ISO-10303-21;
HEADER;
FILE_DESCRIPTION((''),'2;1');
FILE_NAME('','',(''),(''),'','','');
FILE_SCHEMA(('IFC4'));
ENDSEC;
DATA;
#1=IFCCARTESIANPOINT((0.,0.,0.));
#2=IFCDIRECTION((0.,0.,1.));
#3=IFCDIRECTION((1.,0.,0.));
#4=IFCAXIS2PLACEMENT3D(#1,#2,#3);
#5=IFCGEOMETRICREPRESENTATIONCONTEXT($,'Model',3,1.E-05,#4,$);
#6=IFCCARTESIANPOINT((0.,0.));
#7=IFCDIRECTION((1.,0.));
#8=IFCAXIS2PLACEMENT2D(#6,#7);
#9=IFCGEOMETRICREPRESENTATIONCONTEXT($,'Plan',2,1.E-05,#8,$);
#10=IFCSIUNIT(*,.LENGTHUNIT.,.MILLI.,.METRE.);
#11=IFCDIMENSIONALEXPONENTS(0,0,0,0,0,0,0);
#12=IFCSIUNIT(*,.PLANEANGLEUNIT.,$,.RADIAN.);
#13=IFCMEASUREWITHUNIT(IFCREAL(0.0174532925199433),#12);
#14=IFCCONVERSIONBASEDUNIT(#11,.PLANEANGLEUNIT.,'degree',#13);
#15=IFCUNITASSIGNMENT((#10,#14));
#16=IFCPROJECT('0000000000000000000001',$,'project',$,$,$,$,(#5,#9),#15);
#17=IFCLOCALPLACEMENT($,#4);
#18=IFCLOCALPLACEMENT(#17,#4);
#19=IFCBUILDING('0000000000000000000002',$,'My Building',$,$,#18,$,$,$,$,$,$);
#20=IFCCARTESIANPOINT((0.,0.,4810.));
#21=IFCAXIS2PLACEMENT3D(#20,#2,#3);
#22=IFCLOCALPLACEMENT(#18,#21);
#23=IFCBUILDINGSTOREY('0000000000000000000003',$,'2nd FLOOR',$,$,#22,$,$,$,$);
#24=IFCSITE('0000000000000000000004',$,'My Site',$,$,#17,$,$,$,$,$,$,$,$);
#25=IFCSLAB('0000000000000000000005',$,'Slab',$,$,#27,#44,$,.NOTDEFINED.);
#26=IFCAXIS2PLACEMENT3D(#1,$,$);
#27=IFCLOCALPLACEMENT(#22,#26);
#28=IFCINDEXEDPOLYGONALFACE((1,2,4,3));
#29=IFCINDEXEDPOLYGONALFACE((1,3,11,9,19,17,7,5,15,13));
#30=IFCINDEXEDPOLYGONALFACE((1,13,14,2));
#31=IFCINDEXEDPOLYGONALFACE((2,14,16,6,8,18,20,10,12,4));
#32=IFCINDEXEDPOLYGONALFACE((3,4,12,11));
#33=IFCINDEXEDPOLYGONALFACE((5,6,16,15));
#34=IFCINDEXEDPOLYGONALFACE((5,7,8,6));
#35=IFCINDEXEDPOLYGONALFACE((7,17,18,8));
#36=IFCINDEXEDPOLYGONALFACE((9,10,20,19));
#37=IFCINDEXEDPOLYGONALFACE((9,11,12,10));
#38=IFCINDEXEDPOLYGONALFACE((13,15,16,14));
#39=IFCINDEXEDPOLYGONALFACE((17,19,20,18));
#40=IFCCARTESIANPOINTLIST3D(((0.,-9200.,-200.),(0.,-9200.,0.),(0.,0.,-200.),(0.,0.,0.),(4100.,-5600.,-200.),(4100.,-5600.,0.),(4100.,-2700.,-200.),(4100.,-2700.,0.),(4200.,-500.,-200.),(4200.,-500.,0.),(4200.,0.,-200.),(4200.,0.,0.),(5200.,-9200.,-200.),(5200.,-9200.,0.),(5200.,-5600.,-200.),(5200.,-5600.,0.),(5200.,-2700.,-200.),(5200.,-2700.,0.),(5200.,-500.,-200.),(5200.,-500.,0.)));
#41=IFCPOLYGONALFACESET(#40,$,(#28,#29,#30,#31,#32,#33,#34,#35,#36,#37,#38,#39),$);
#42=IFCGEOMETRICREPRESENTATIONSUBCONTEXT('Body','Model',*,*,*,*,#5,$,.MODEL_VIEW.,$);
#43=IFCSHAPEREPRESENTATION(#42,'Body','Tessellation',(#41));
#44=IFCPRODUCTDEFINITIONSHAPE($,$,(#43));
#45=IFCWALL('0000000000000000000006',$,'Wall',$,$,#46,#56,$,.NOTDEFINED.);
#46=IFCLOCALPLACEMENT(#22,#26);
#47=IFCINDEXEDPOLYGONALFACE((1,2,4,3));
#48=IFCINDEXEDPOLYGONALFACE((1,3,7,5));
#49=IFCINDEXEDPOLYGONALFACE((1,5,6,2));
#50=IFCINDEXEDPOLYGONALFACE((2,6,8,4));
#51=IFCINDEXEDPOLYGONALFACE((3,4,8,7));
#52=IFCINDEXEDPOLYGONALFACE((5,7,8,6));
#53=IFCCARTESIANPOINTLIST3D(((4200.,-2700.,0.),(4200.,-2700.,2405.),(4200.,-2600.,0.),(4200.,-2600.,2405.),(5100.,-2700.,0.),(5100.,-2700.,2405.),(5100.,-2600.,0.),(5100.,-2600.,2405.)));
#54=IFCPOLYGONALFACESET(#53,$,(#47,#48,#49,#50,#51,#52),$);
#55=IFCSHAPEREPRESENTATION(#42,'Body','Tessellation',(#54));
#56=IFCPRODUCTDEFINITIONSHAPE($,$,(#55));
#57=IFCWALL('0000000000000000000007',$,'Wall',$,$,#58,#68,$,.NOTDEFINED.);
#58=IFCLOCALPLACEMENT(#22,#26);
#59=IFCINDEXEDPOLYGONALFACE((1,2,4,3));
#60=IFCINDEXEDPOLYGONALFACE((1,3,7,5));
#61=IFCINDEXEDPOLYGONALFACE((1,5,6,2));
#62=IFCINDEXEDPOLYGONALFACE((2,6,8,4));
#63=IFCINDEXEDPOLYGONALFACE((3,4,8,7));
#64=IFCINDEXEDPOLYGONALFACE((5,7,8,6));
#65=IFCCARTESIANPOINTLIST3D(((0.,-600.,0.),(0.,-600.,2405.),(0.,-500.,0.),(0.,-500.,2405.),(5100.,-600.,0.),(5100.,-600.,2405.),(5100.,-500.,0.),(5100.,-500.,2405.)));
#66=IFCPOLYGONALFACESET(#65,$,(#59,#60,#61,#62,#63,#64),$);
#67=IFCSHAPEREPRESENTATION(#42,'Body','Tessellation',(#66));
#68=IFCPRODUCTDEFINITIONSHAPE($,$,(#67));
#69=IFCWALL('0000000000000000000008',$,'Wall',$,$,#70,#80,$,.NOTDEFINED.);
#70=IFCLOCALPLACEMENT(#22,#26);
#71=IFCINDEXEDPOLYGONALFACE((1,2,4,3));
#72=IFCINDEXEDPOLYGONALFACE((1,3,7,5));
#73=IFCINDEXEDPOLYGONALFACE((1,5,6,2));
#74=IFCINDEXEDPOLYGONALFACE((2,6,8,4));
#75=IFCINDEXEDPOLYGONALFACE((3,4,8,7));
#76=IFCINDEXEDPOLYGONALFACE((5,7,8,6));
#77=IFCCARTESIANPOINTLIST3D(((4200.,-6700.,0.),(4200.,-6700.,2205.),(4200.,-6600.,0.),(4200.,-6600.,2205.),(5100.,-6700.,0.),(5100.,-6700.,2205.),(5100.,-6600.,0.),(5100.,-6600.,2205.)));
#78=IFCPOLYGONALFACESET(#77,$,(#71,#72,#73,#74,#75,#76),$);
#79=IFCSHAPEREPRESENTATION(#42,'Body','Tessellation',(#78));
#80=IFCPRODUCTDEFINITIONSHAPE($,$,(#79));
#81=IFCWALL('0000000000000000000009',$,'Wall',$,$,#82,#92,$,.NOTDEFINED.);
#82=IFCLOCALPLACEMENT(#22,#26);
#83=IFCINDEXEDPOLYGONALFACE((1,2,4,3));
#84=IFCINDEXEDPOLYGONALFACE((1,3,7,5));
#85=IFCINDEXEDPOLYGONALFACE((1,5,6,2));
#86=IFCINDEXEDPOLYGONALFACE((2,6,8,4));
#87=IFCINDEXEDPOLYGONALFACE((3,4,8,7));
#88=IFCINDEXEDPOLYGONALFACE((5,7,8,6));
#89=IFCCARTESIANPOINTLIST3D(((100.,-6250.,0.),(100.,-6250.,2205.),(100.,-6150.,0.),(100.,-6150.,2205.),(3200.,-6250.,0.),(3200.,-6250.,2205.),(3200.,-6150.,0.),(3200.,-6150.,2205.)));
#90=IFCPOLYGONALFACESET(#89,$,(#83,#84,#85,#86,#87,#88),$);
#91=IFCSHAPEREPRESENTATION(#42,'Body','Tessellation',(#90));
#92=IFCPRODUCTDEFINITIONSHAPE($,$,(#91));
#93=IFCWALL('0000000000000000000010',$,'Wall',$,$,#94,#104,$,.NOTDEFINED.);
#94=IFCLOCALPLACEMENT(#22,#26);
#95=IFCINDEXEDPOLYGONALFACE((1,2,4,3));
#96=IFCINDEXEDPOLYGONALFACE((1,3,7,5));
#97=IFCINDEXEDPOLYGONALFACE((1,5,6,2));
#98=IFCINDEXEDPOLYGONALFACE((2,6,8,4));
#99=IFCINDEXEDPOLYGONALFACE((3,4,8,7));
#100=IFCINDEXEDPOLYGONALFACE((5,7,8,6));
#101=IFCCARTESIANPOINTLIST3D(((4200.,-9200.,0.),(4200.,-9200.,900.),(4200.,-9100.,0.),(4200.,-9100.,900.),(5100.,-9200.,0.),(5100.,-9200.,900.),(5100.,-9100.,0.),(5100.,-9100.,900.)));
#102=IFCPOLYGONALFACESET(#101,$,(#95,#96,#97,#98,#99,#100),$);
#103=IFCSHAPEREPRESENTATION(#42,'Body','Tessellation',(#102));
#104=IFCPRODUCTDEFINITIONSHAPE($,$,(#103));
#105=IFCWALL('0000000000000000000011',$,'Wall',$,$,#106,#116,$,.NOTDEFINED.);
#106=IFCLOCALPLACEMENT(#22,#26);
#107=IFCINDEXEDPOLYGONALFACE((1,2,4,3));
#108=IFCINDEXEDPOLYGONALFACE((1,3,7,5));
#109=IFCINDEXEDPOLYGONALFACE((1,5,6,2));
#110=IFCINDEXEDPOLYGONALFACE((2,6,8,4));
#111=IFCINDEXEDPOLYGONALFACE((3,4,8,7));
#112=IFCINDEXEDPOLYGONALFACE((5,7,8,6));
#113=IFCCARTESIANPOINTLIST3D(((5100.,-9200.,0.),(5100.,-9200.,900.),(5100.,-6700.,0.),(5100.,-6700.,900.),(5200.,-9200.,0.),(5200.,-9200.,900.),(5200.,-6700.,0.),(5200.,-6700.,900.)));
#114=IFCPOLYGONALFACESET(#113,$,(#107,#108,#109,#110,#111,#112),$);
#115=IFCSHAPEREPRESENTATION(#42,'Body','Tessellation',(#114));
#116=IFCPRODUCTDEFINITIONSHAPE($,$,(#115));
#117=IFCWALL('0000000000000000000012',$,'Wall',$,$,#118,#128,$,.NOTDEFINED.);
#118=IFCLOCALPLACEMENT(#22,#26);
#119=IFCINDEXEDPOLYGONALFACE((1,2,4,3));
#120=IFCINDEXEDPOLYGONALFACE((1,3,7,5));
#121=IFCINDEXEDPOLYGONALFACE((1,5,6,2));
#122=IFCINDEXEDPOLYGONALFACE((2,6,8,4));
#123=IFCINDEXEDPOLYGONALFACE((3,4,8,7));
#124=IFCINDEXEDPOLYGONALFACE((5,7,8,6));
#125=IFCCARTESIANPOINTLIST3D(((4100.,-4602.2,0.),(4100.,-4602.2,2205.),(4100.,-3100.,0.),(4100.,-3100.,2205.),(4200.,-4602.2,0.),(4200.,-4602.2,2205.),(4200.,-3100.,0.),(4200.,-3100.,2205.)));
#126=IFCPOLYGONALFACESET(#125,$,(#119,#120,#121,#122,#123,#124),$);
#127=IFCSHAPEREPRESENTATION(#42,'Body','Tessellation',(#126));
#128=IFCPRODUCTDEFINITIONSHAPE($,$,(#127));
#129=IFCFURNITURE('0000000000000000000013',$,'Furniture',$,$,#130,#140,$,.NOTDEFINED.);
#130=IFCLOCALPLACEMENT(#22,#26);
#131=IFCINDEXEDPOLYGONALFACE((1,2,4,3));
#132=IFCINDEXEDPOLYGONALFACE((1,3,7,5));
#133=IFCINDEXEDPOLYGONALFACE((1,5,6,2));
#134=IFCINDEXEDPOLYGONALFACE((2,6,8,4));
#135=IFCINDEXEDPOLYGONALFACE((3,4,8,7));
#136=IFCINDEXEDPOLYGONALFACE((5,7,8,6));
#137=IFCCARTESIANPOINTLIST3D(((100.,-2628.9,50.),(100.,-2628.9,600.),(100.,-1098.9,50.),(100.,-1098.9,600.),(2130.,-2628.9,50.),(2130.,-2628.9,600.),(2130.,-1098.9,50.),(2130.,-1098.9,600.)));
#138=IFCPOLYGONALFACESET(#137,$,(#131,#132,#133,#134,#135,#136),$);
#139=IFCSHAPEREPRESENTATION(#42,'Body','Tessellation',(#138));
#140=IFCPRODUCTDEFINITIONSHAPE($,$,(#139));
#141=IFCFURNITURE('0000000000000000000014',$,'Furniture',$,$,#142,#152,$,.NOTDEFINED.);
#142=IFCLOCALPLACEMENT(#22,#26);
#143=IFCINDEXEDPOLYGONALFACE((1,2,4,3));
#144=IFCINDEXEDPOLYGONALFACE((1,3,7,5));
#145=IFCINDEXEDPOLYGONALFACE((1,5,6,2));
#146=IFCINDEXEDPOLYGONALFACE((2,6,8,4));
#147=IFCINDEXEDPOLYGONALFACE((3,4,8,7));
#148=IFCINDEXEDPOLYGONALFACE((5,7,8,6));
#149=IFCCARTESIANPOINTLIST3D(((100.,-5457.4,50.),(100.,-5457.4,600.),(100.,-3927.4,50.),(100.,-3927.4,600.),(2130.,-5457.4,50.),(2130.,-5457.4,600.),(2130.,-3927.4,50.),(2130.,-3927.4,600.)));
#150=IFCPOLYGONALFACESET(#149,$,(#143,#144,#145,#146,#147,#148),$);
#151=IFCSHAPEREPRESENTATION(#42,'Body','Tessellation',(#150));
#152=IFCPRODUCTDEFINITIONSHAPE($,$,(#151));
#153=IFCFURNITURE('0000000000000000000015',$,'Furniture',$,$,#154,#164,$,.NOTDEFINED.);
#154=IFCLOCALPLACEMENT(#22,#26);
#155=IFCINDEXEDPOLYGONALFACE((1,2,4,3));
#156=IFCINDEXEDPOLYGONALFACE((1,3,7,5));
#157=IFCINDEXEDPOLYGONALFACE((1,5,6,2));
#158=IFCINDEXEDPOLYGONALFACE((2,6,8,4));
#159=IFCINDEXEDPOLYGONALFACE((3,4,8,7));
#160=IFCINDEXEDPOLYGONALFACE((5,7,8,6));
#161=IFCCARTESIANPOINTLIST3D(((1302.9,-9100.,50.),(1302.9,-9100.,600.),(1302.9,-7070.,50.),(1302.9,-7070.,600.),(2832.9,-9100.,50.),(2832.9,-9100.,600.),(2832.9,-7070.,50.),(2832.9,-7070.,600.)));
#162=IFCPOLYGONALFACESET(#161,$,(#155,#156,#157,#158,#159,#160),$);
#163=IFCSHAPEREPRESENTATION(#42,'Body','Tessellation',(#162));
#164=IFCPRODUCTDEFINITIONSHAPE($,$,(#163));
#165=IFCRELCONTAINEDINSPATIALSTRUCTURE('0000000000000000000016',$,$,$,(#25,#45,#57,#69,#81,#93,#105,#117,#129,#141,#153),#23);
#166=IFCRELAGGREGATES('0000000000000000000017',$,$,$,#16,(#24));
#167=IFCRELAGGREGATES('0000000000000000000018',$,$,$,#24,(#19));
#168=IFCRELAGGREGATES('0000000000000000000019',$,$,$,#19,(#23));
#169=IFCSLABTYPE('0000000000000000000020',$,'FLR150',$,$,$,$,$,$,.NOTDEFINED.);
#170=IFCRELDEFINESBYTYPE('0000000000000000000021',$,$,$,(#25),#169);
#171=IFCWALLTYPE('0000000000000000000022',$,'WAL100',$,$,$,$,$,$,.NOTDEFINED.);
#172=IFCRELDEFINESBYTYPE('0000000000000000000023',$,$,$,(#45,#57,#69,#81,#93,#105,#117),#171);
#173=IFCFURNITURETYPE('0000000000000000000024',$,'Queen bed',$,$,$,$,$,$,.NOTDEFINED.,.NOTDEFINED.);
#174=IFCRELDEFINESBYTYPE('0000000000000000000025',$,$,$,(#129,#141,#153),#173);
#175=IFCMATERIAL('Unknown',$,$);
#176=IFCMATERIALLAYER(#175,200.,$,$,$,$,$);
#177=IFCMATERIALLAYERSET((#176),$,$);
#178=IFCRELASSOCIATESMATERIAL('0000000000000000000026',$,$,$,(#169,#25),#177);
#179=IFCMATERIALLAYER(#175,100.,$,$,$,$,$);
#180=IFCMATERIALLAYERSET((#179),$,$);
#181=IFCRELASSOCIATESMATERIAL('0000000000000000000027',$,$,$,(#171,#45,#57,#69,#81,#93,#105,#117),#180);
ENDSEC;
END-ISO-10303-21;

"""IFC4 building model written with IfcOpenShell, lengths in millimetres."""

from ifc_helpers import new_model, entity, si_unit, converted_unit, frame, origin_with_axes, origin_2d_with_axis, place, context, subcontext, project, spatial, line, indexed_curve, outline, extrude, source, transform, mapped, material, layer, layer_set, layer_usage, type_object, type_shapes, element, save


model = new_model("IFC4")

# Units and contexts
model_context = context("Model", 3, precision=1e-05, world=origin_with_axes())
plan_context = context("Plan", 2, precision=1e-05, world=origin_2d_with_axis())
body_context = subcontext(model_context, "Body", "Model", "MODEL_VIEW")
ifc_project = project(units=[si_unit("LENGTHUNIT", "METRE", prefix="MILLI"), converted_unit("PLANEANGLEUNIT", "degree", entity("IfcReal", 0.0174532925199433), si_unit("PLANEANGLEUNIT", "RADIAN"), dimensions=[0, 0, 0, 0, 0, 0, 0])], contexts=[model_context, plan_context])

# Site, building, storey
site_placement = place(None, origin_with_axes())
site = spatial("IfcSite", under=ifc_project, at=site_placement, Name="My Site")
building_placement = place(site_placement, origin_with_axes())
building = spatial("IfcBuilding", under=site, at=building_placement, Name="My Building")
storey_placement = place(building_placement, frame((0.0, 0.0, 4810.0), z_axis=(0.0, 0.0, 1.0), x_axis=(1.0, 0.0, 0.0)))
storey = spatial("IfcBuildingStorey", under=building, at=storey_placement, Name="2nd FLOOR")

# Slab
ifc_material = material(Name="Unknown")
ifc_layer_1 = layer(ifc_material, 200.0)
ifc_layer_set_1 = layer_set([ifc_layer_1])
ifc_layer_usage_1 = layer_usage(ifc_layer_set_1, "AXIS3", "POSITIVE", 0.0)
slab_type = type_object("IfcSlabType", Name="FLR150", PredefinedType="NOTDEFINED", material=ifc_layer_set_1)
slab_placement = place(storey_placement, frame((0.0, -9200.0, -200.0), z_axis=(0.0, 0.0, 1.0), x_axis=(1.0, 0.0, 0.0)))
element("IfcSlab", 1, at=slab_placement, inside=storey, type_object=slab_type, material=ifc_layer_usage_1, Name="Slab", PredefinedType="NOTDEFINED", context=body_context, shape_type="SweptSolid", body=[
    extrude(outline(indexed_curve([(5200.0, 3600.0), (4100.0, 3600.0), (4100.0, 6500.0), (5200.0, 6500.0), (5200.0, 8700.0), (4200.0, 8700.0), (4200.0, 9200.0), (0.0, 9200.0), (0.0, 0.0), (5200.0, 0.0)], segments=[line(5, 4), line(4, 3), line(3, 2), line(2, 1), line(1, 10), line(10, 9), line(9, 8), line(8, 7), line(7, 6), line(6, 5)], self_intersect=False)), None, (0.0, 0.0, 1.0), 200.0),
])

# Walls
ifc_layer_2 = layer(ifc_material, 100.0)
ifc_layer_set_2 = layer_set([ifc_layer_2])
ifc_layer_usage_2 = layer_usage(ifc_layer_set_2, "AXIS2", "POSITIVE", 0.0)
wall_type = type_object("IfcWallType", Name="WAL100", PredefinedType="NOTDEFINED", material=ifc_layer_set_2)
wall_1_placement = place(storey_placement, frame((5100.0, -2600.0, 0.0), z_axis=(0.0, 0.0, 1.0), x_axis=(-1.0, 0.0, 0.0)))
element("IfcWall", 2, at=wall_1_placement, inside=storey, type_object=wall_type, material=ifc_layer_usage_2, Name="Wall", PredefinedType="NOTDEFINED", context=body_context, shape_type="SweptSolid", body=[
    extrude(outline(indexed_curve([(0.0, 0.0), (0.0, 100.0), (900.0, 100.0), (900.0, 0.0), (0.0, 0.0)], self_intersect=False)), origin_with_axes(), (0.0, 0.0, 1.0), 2405.0),
])
ifc_layer_usage_3 = layer_usage(ifc_layer_set_2, "AXIS2", "POSITIVE", 0.0)
wall_2_placement = place(storey_placement, frame((5100.0, -500.0, 0.0), z_axis=(0.0, 0.0, 1.0), x_axis=(-1.0, 0.0, 0.0)))
element("IfcWall", 3, at=wall_2_placement, inside=storey, type_object=wall_type, material=ifc_layer_usage_3, Name="Wall", PredefinedType="NOTDEFINED", context=body_context, shape_type="SweptSolid", body=[
    extrude(outline(indexed_curve([(0.0, 0.0), (0.0, 100.0), (5100.0, 100.0), (5100.0, 0.0), (0.0, 0.0)], self_intersect=False)), origin_with_axes(), (0.0, 0.0, 1.0), 2405.0),
])
ifc_layer_usage_4 = layer_usage(ifc_layer_set_2, "AXIS2", "POSITIVE", 0.0)
wall_3_placement = place(storey_placement, frame((5100.0, -6600.0, 0.0), z_axis=(0.0, 0.0, 1.0), x_axis=(-1.0, 0.0, 0.0)))
element("IfcWall", 4, at=wall_3_placement, inside=storey, type_object=wall_type, material=ifc_layer_usage_4, Name="Wall", PredefinedType="NOTDEFINED", context=body_context, shape_type="SweptSolid", body=[
    extrude(outline(indexed_curve([(0.0, 0.0), (0.0, 100.0), (900.0, 100.0), (900.0, 0.0), (0.0, 0.0)], self_intersect=False)), origin_with_axes(), (0.0, 0.0, 1.0), 2205.0),
])
ifc_layer_usage_5 = layer_usage(ifc_layer_set_2, "AXIS2", "POSITIVE", 0.0)
wall_4_placement = place(storey_placement, frame((3200.0, -6150.0, 0.0), z_axis=(0.0, 0.0, 1.0), x_axis=(-1.0, 0.000001, 0.0)))
element("IfcWall", 5, at=wall_4_placement, inside=storey, type_object=wall_type, material=ifc_layer_usage_5, Name="Wall", PredefinedType="NOTDEFINED", context=body_context, shape_type="SweptSolid", body=[
    extrude(outline(indexed_curve([(0.0, 0.0), (0.0, 100.0), (3100.0, 100.0), (3100.0, 0.0), (0.0, 0.0)], self_intersect=False)), origin_with_axes(), (0.0, 0.0, 1.0), 2205.0),
])
ifc_layer_usage_6 = layer_usage(ifc_layer_set_2, "AXIS2", "POSITIVE", 0.0)
wall_5_placement = place(storey_placement, frame((4200.0, -9200.0, 0.0), z_axis=(0.0, 0.0, 1.0), x_axis=(1.0, -0.000001, 0.0)))
element("IfcWall", 6, at=wall_5_placement, inside=storey, type_object=wall_type, material=ifc_layer_usage_6, Name="Wall", PredefinedType="NOTDEFINED", context=body_context, shape_type="SweptSolid", body=[
    extrude(outline(indexed_curve([(0.0, 0.0), (0.0, 100.0), (900.0, 100.0), (900.0, 0.0), (0.0, 0.0)], self_intersect=False)), origin_with_axes(), (0.0, 0.0, 1.0), 900.0),
])
ifc_layer_usage_7 = layer_usage(ifc_layer_set_2, "AXIS2", "POSITIVE", 0.0)
wall_6_placement = place(storey_placement, frame((5100.0, -6700.0, 0.0), z_axis=(0.0, 0.0, 1.0), x_axis=(-0.000001, -1.0, 0.0)))
element("IfcWall", 7, at=wall_6_placement, inside=storey, type_object=wall_type, material=ifc_layer_usage_7, Name="Wall", PredefinedType="NOTDEFINED", context=body_context, shape_type="SweptSolid", body=[
    extrude(outline(indexed_curve([(0.0, 0.0), (0.0, 100.0), (2500.0, 100.0), (2500.0, 0.0), (0.0, 0.0)], self_intersect=False)), origin_with_axes(), (0.0, 0.0, 1.0), 900.0),
])
ifc_layer_usage_8 = layer_usage(ifc_layer_set_2, "AXIS2", "POSITIVE", 0.0)
wall_7_placement = place(storey_placement, frame((4200.0, -4602.2, 0.0), z_axis=(0.0, 0.0, 1.0), x_axis=(0.000001, 1.0, 0.0)))
element("IfcWall", 8, at=wall_7_placement, inside=storey, type_object=wall_type, material=ifc_layer_usage_8, Name="Wall", PredefinedType="NOTDEFINED", context=body_context, shape_type="SweptSolid", body=[
    extrude(outline(indexed_curve([(0.0, 0.0), (0.0, 100.0), (1502.2, 100.0), (1502.2, 0.0), (0.0, 0.0)], self_intersect=False)), origin_with_axes(), (0.0, 0.0, 1.0), 2205.0),
])

# Furniture
furniture_type = type_object("IfcFurnitureType", Name="Queen bed", AssemblyPlace="NOTDEFINED", PredefinedType="NOTDEFINED")
shared_shape = source(origin_with_axes(), body_context, "Body", "SweptSolid", [
    extrude(outline(indexed_curve([(0.0, 0.0), (0.0, 2030.0), (1530.0, 2030.0), (1530.0, 0.0)], segments=[line(1, 2), line(2, 3), line(3, 4), line(4, 1)])), origin_with_axes(), (0.0, 0.0, 1.0), 550.0),
])
type_shapes(furniture_type, [shared_shape])
for number, where, z_axis, x_axis, name in (
    (9, (2130.0, -2628.9, 50.0), (0.0, 0.0, 1.0), (0.0, 1.0, 0.0), "Furniture"),
    (10, (2130.0, -5457.4, 50.0), (0.0, 0.0, 1.0), (0.0, 1.0, 0.0), "Furniture"),
    (11, (2832.9, -7070.0, 50.0), (0.0, 0.0, 1.0), (-1.0, 0.0, 0.0), "Furniture"),
):
    element("IfcFurniture", number, at=place(storey_placement, frame(where, z_axis=z_axis, x_axis=x_axis)), inside=storey, type_object=furniture_type, Name=name, PredefinedType="NOTDEFINED", context=body_context, shape_type="MappedRepresentation", body=[
        mapped(shared_shape, transform((0.0, 0.0, 0.0), x_axis=(1.0, 0.0, 0.0), y_axis=(0.0, 1.0, 0.0), z_axis=(0.0, 0.0, 1.0), scale=1.0)),
    ])

save(model, "model.ifc")
